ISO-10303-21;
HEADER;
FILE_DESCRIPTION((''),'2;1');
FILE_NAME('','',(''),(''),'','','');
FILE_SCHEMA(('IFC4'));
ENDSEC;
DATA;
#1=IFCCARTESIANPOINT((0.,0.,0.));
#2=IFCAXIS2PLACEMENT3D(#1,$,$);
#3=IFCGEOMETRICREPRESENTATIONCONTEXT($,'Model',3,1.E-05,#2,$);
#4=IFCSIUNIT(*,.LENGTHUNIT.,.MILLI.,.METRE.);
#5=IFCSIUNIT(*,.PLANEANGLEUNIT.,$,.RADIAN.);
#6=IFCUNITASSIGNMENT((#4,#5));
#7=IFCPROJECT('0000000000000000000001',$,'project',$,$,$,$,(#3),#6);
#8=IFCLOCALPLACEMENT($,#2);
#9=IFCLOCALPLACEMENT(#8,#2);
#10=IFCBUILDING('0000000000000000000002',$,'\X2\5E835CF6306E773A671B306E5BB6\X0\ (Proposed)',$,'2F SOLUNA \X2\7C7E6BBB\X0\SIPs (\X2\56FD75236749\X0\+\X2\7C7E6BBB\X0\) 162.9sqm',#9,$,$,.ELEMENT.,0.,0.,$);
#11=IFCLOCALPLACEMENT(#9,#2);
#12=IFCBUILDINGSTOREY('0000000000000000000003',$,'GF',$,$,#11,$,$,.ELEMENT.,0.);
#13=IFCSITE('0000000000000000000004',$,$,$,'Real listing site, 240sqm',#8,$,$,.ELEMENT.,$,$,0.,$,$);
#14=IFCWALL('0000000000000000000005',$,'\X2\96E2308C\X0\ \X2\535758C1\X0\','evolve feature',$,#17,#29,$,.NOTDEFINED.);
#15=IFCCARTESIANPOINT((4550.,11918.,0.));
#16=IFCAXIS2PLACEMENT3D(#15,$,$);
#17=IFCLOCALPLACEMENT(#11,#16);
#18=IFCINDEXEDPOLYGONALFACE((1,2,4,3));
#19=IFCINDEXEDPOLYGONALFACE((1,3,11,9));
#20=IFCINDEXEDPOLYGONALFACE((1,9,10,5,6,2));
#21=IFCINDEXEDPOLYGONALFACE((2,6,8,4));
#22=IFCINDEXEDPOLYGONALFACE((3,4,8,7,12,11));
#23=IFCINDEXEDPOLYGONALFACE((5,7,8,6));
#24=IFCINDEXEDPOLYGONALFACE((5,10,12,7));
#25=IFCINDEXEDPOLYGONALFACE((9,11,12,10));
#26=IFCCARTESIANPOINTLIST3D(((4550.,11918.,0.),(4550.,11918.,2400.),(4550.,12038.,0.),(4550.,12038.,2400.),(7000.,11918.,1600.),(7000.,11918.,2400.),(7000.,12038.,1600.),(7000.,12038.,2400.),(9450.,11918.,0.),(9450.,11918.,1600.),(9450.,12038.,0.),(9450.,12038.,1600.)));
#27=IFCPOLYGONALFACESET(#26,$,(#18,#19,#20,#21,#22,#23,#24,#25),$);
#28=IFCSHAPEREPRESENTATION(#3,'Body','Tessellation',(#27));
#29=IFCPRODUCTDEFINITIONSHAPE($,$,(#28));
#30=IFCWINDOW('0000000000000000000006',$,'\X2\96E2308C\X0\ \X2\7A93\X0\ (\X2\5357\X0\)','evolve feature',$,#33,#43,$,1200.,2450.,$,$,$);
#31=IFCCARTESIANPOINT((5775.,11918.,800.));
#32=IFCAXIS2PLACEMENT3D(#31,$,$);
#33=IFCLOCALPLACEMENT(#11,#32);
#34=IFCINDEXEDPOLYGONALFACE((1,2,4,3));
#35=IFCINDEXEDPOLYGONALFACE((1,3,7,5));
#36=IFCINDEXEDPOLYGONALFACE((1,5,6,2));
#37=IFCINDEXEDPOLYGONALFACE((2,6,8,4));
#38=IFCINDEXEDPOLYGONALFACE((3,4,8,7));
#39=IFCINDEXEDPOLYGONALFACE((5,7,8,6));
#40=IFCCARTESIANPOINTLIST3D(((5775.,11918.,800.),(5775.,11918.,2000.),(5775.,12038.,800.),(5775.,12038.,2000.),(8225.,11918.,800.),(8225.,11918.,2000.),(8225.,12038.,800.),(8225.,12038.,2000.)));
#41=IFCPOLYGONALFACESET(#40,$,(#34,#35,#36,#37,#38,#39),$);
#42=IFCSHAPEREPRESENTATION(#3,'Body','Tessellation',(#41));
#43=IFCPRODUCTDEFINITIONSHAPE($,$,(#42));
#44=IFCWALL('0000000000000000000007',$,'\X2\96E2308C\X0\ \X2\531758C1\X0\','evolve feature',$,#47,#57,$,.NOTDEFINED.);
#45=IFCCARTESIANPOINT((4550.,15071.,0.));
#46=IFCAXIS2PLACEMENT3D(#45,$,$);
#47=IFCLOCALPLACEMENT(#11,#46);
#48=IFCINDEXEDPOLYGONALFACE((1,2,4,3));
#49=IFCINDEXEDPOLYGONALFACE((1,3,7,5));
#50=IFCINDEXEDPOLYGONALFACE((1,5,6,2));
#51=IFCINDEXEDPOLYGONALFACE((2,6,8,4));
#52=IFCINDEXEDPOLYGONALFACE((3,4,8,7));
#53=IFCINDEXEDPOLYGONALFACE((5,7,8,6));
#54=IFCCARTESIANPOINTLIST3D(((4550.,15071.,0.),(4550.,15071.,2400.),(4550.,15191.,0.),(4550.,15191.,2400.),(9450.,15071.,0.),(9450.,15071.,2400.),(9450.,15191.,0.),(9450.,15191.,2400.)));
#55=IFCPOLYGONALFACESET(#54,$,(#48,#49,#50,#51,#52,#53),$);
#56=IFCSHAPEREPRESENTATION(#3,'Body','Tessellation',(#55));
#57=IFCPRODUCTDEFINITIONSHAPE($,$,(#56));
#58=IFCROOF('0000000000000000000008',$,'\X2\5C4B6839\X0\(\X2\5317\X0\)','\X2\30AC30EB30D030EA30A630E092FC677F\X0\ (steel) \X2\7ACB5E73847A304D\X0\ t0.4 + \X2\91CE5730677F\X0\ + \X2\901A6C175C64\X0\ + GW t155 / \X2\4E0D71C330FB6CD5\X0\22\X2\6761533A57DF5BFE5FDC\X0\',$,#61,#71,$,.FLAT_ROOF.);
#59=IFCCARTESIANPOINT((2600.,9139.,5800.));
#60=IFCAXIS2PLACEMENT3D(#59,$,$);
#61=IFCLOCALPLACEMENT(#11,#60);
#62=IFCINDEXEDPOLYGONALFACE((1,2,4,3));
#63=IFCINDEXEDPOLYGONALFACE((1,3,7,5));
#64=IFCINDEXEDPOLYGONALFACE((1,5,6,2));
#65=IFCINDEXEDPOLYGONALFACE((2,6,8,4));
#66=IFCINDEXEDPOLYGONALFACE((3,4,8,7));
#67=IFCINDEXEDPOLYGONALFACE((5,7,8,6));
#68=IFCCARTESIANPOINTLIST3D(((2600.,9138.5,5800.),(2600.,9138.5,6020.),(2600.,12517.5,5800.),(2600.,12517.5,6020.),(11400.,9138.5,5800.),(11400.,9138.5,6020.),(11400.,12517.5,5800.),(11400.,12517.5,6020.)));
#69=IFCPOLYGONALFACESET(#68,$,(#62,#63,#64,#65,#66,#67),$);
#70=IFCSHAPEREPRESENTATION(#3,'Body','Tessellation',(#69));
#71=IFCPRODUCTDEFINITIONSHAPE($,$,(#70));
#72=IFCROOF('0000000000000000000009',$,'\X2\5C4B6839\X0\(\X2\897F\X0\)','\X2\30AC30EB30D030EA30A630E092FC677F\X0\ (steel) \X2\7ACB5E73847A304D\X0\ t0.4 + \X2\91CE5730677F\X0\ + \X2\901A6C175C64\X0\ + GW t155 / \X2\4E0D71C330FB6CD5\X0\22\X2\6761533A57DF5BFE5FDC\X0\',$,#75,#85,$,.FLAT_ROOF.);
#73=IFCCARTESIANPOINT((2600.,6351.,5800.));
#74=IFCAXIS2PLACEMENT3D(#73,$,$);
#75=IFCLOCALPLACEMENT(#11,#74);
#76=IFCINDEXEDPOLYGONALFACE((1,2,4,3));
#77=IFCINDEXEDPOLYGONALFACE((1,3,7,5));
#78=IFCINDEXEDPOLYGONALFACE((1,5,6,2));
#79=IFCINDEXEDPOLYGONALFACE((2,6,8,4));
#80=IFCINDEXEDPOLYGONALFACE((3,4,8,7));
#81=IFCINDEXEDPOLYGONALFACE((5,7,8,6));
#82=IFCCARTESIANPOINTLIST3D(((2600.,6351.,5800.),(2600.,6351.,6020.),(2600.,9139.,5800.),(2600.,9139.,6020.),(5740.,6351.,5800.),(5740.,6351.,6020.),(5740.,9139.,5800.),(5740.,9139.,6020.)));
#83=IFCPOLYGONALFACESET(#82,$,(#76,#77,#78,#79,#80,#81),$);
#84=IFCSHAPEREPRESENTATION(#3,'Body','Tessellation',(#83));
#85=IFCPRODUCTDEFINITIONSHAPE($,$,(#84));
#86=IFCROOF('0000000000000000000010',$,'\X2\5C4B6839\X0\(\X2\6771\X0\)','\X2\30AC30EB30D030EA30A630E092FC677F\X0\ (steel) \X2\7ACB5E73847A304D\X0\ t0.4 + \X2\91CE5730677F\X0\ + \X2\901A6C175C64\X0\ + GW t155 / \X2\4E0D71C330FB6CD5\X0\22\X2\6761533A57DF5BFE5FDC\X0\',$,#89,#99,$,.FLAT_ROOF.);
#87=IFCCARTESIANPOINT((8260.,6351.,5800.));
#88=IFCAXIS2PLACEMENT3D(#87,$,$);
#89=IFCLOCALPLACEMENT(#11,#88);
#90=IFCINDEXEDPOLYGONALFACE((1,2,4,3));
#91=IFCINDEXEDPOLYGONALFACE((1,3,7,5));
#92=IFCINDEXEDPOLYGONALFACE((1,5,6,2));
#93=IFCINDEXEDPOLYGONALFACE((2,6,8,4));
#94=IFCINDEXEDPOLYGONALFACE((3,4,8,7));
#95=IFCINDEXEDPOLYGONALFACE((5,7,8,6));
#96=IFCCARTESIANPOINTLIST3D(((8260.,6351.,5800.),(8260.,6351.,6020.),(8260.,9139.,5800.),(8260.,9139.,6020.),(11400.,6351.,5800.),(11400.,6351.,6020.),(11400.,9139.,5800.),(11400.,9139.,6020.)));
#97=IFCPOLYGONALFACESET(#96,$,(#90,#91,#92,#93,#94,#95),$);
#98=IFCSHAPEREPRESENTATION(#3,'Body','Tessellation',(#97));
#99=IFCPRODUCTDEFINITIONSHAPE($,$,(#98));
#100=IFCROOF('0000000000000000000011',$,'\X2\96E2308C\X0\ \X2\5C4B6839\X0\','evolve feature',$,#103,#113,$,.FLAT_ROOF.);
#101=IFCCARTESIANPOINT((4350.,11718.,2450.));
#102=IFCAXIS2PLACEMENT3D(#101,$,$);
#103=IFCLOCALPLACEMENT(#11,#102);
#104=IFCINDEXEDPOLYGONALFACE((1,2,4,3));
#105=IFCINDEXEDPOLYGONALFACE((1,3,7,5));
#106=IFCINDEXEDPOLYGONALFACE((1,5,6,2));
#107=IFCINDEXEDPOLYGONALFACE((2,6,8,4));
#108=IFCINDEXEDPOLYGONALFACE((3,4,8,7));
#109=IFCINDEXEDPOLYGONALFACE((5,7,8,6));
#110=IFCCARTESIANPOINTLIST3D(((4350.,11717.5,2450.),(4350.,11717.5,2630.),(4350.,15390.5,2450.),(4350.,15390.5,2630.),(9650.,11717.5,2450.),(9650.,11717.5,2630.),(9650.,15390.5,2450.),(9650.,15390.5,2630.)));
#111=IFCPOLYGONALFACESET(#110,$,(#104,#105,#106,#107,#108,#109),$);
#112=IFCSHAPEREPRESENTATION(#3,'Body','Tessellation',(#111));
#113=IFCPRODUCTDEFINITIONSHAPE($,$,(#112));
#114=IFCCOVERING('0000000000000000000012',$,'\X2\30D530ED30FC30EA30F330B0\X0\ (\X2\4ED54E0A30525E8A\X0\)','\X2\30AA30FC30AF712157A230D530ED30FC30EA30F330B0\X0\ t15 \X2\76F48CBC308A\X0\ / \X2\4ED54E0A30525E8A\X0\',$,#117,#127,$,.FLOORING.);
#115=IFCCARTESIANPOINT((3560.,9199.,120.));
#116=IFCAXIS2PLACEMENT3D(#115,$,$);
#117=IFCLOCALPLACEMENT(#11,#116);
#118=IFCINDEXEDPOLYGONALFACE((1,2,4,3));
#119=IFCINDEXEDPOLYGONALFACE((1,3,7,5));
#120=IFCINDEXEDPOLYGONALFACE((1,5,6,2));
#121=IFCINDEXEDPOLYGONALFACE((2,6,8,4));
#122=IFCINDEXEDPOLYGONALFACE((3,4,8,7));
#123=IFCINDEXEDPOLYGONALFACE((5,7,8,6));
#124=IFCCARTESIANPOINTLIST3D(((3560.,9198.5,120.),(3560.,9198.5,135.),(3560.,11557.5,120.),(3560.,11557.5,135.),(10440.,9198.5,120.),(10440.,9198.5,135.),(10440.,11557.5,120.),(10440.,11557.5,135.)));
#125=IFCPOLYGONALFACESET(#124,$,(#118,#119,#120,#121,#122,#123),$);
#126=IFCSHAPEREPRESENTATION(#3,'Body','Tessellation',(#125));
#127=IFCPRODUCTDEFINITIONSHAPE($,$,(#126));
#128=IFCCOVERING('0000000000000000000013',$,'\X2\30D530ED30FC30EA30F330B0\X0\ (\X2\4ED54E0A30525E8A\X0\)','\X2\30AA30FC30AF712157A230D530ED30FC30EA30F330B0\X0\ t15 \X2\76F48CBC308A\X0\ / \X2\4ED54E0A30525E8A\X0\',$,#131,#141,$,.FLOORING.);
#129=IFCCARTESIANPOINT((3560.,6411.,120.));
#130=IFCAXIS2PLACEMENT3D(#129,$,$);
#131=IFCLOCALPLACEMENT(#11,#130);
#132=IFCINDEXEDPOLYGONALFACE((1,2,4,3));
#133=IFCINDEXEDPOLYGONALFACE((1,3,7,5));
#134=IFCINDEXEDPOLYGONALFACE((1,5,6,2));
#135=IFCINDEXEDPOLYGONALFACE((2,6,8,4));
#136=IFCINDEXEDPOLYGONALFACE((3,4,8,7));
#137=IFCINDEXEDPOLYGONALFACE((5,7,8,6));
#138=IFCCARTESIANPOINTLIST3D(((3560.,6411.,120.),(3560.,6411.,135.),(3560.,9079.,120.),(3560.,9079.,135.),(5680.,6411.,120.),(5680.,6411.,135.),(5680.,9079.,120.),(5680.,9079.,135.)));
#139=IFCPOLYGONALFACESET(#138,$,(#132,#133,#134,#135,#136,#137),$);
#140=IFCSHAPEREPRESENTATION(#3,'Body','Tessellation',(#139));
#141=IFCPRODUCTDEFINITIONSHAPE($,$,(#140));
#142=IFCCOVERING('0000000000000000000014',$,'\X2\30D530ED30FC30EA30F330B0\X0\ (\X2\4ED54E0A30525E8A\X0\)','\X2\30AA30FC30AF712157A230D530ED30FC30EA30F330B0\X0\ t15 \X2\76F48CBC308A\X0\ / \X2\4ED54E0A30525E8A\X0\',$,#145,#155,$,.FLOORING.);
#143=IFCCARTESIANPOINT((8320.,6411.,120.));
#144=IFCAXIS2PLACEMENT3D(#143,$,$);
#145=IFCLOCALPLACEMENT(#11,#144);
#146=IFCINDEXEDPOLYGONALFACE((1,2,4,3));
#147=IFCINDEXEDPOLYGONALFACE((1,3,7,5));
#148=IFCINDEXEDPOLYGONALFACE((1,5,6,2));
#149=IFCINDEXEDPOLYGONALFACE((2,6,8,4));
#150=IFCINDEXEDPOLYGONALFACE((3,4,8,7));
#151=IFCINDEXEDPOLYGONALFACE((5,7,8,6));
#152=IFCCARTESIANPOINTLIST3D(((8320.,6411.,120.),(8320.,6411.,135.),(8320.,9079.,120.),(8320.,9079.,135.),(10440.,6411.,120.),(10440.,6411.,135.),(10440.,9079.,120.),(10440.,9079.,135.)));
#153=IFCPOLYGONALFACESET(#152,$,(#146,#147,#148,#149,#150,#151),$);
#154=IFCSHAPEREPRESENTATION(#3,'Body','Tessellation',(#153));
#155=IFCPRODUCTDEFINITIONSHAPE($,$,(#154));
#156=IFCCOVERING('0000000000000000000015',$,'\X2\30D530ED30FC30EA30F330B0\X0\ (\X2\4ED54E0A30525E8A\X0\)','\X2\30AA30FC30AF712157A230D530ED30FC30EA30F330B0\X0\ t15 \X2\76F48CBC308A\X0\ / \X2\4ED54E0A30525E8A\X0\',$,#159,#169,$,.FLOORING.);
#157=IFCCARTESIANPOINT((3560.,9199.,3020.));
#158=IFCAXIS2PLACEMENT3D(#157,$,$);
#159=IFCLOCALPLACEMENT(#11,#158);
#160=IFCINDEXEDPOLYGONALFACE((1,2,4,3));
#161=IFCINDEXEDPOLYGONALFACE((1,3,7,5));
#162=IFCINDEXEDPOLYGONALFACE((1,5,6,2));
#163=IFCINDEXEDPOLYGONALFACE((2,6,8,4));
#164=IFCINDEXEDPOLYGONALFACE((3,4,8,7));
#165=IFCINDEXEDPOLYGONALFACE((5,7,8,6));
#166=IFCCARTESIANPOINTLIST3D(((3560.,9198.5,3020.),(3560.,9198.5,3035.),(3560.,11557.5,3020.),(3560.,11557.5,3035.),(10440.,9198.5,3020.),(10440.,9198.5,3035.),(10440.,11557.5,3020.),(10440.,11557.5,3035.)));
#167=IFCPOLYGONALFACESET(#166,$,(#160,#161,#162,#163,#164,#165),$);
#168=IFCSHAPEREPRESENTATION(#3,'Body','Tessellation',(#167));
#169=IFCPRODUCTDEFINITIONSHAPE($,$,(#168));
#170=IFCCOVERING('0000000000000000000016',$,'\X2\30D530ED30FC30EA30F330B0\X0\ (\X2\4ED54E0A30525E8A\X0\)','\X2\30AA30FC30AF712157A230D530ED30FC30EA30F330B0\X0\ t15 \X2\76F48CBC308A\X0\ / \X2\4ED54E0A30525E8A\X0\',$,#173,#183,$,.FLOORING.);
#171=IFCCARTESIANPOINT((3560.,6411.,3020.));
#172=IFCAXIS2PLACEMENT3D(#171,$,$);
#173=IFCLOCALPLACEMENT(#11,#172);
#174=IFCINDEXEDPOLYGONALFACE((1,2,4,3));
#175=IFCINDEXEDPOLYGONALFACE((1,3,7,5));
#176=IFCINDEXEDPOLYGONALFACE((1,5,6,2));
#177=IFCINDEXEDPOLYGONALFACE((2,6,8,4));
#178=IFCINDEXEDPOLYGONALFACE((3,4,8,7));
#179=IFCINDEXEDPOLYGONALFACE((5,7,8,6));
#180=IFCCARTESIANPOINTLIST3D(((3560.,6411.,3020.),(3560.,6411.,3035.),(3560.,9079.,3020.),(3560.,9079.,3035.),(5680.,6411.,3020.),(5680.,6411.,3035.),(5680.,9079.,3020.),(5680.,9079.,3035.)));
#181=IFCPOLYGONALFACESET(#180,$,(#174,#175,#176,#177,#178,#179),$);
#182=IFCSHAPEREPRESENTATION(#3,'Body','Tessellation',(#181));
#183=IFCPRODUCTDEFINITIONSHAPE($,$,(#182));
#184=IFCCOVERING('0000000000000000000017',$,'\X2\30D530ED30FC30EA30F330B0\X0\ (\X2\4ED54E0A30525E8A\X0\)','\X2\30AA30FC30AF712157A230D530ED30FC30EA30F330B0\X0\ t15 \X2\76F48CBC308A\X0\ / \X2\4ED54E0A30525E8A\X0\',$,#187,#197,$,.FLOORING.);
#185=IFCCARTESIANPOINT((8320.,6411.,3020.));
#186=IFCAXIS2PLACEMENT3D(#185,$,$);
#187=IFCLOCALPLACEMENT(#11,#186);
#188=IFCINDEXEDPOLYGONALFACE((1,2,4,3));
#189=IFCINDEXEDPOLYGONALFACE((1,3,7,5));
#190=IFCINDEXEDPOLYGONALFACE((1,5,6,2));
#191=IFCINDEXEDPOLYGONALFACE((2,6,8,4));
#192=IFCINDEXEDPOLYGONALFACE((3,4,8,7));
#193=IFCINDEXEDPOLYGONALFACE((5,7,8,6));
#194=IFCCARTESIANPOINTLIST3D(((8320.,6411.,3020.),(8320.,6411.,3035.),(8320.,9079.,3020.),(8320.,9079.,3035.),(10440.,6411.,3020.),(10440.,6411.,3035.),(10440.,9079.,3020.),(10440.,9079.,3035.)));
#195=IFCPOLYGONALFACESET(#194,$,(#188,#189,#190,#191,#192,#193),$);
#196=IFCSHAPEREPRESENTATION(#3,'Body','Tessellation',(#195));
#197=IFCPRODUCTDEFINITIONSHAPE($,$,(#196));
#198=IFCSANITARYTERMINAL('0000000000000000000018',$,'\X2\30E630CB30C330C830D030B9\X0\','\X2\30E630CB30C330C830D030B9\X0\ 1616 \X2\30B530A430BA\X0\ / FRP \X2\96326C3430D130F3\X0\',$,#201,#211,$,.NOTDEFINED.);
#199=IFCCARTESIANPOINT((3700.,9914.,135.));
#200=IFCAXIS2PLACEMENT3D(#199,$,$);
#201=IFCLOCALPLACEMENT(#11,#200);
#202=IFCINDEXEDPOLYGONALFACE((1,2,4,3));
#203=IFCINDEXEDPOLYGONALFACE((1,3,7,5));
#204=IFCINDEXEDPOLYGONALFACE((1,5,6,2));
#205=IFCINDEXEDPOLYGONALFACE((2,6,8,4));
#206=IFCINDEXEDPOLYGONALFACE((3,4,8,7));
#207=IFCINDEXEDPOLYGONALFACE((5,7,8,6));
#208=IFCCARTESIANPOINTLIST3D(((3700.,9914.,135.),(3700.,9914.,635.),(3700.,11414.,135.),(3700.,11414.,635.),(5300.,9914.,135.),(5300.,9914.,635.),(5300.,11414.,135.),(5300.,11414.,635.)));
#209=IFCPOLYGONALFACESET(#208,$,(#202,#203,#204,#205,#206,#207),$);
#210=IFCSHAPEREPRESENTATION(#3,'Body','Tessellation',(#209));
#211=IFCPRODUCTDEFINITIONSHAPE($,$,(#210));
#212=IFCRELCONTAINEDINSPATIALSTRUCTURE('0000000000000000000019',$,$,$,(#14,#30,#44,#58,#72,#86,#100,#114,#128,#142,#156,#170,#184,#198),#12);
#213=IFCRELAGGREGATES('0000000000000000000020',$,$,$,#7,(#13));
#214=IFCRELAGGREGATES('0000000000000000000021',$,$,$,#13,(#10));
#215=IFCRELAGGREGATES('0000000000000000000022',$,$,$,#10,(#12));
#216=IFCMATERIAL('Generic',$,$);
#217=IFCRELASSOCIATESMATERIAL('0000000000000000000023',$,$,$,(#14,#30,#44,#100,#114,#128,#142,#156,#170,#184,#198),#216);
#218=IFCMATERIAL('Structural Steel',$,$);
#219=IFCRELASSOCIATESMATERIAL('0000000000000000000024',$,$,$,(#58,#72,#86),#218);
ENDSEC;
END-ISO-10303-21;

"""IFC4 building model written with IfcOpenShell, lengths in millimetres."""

from ifc_helpers import new_model, si_unit, frame, frame_2d, origin, place, context, project, spatial, rectangle, extrude, material, element, fill, save


model = new_model("IFC4")

# Units and contexts
model_context = context("Model", 3, precision=1e-05, world=origin())
ifc_project = project(units=[si_unit("LENGTHUNIT", "METRE", prefix="MILLI"), si_unit("PLANEANGLEUNIT", "RADIAN")], contexts=[model_context])

# Site, building, storey
site_placement = place(None, origin())
site = spatial("IfcSite", under=ifc_project, at=site_placement, ObjectType="Real listing site, 240sqm", CompositionType="ELEMENT", RefElevation=0.0)
building_placement = place(site_placement, origin())
building = spatial("IfcBuilding", under=site, at=building_placement, Name="広島の眺望の家 (Proposed)", ObjectType="2F SOLUNA 籾殻SIPs (国産杉+籾殻) 162.9sqm", CompositionType="ELEMENT", ElevationOfRefHeight=0.0, ElevationOfTerrain=0.0)
storey_placement = place(building_placement, origin())
storey = spatial("IfcBuildingStorey", under=building, at=storey_placement, Name="GF", CompositionType="ELEMENT", Elevation=0.0)

# Shared definitions
ifc_material_1 = material(Name="Generic")

# Wall, opening, window
wall_1_placement = place(storey_placement, frame((4550.0, 11918.0, 0.0)))
wall_1 = element("IfcWall", 1, at=wall_1_placement, inside=storey, material=ifc_material_1, Name="離れ 南壁", Description="evolve feature", PredefinedType="NOTDEFINED", context=model_context, shape_type="SweptSolid", body=[
    extrude(rectangle(XDim=4900.0, YDim=120.0, at=frame_2d((2450.0, 60.0))), frame((4550.0, 11918.0, 0.0)), (0.0, 0.0, 1.0), 2400.0),
])
opening_1_placement = place(storey_placement, frame((5775.0, 11918.0, 800.0)))
opening_1 = element("IfcOpeningElement", 2, at=opening_1_placement, cuts=wall_1, PredefinedType="NOTDEFINED", context=model_context, shape_type="SweptSolid", body=[
    extrude(rectangle(XDim=2450.0, YDim=120.0, at=frame_2d((1225.0, 60.0))), frame((5775.0, 11918.0, 800.0)), (0.0, 0.0, 1.0), 1200.0),
])
window_1_placement = place(storey_placement, frame((5775.0, 11918.0, 800.0)))
window_1 = element("IfcWindow", 3, at=window_1_placement, inside=storey, material=ifc_material_1, Name="離れ 窓 (南)", Description="evolve feature", OverallHeight=1200.0, OverallWidth=2450.0, context=model_context, shape_type="SweptSolid", body=[
    extrude(rectangle(XDim=2450.0, YDim=120.0, at=frame_2d((1225.0, 60.0))), frame((5775.0, 11918.0, 800.0)), (0.0, 0.0, 1.0), 1200.0),
])
fill(opening_1, window_1)

# Wall
wall_2_placement = place(storey_placement, frame((4550.0, 15071.0, 0.0)))
element("IfcWall", 4, at=wall_2_placement, inside=storey, material=ifc_material_1, Name="離れ 北壁", Description="evolve feature", PredefinedType="NOTDEFINED", context=model_context, shape_type="SweptSolid", body=[
    extrude(rectangle(XDim=4900.0, YDim=120.0, at=frame_2d((2450.0, 60.0))), frame((4550.0, 15071.0, 0.0)), (0.0, 0.0, 1.0), 2400.0),
])

# Roofs
ifc_material_2 = material(Name="Structural Steel")
for number, where, name in (
    (5, (2600.0, 9139.0, 5800.0), "屋根(北)"),
):
    element("IfcRoof", number, at=place(storey_placement, frame(where)), inside=storey, material=ifc_material_2, Name=name, Description="ガルバリウム鋼板 (steel) 立平葺き t0.4 + 野地板 + 通気層 + GW t155 / 不燃・法22条区域対応", PredefinedType="FLAT_ROOF", context=model_context, shape_type="SweptSolid", body=[
        extrude(rectangle(XDim=8800.0, YDim=3379.0, at=frame_2d((4400.0, 1689.0))), frame((2600.0, 9139.0, 5800.0)), (0.0, 0.0, 1.0), 220.0),
    ])
roof_1_placement = place(storey_placement, frame((2600.0, 6351.0, 5800.0)))
element("IfcRoof", 6, at=roof_1_placement, inside=storey, material=ifc_material_2, Name="屋根(西)", Description="ガルバリウム鋼板 (steel) 立平葺き t0.4 + 野地板 + 通気層 + GW t155 / 不燃・法22条区域対応", PredefinedType="FLAT_ROOF", context=model_context, shape_type="SweptSolid", body=[
    extrude(rectangle(XDim=3140.0, YDim=2788.0, at=frame_2d((1570.0, 1394.0))), frame((2600.0, 6351.0, 5800.0)), (0.0, 0.0, 1.0), 220.0),
])
roof_2_placement = place(storey_placement, frame((8260.0, 6351.0, 5800.0)))
element("IfcRoof", 7, at=roof_2_placement, inside=storey, material=ifc_material_2, Name="屋根(東)", Description="ガルバリウム鋼板 (steel) 立平葺き t0.4 + 野地板 + 通気層 + GW t155 / 不燃・法22条区域対応", PredefinedType="FLAT_ROOF", context=model_context, shape_type="SweptSolid", body=[
    extrude(rectangle(XDim=3140.0, YDim=2788.0, at=frame_2d((1570.0, 1394.0))), frame((8260.0, 6351.0, 5800.0)), (0.0, 0.0, 1.0), 220.0),
])
roof_3_placement = place(storey_placement, frame((4350.0, 11718.0, 2450.0)))
element("IfcRoof", 8, at=roof_3_placement, inside=storey, material=ifc_material_1, Name="離れ 屋根", Description="evolve feature", PredefinedType="FLAT_ROOF", context=model_context, shape_type="SweptSolid", body=[
    extrude(rectangle(XDim=5300.0, YDim=3673.0, at=frame_2d((2650.0, 1836.0))), frame((4350.0, 11718.0, 2450.0)), (0.0, 0.0, 1.0), 180.0),
])

# Coverings
covering_1_placement = place(storey_placement, frame((3560.0, 9199.0, 120.0)))
element("IfcCovering", 9, at=covering_1_placement, inside=storey, material=ifc_material_1, Name="フローリング (仕上げ床)", Description="オーク無垢フローリング t15 直貼り / 仕上げ床", PredefinedType="FLOORING", context=model_context, shape_type="SweptSolid", body=[
    extrude(rectangle(XDim=6880.0, YDim=2359.0, at=frame_2d((3440.0, 1179.0))), frame((3560.0, 9199.0, 120.0)), (0.0, 0.0, 1.0), 15.0),
])
covering_2_placement = place(storey_placement, frame((3560.0, 6411.0, 120.0)))
element("IfcCovering", 10, at=covering_2_placement, inside=storey, material=ifc_material_1, Name="フローリング (仕上げ床)", Description="オーク無垢フローリング t15 直貼り / 仕上げ床", PredefinedType="FLOORING", context=model_context, shape_type="SweptSolid", body=[
    extrude(rectangle(XDim=2120.0, YDim=2668.0, at=frame_2d((1060.0, 1334.0))), frame((3560.0, 6411.0, 120.0)), (0.0, 0.0, 1.0), 15.0),
])
covering_3_placement = place(storey_placement, frame((8320.0, 6411.0, 120.0)))
element("IfcCovering", 11, at=covering_3_placement, inside=storey, material=ifc_material_1, Name="フローリング (仕上げ床)", Description="オーク無垢フローリング t15 直貼り / 仕上げ床", PredefinedType="FLOORING", context=model_context, shape_type="SweptSolid", body=[
    extrude(rectangle(XDim=2120.0, YDim=2668.0, at=frame_2d((1060.0, 1334.0))), frame((8320.0, 6411.0, 120.0)), (0.0, 0.0, 1.0), 15.0),
])
covering_4_placement = place(storey_placement, frame((3560.0, 9199.0, 3020.0)))
element("IfcCovering", 12, at=covering_4_placement, inside=storey, material=ifc_material_1, Name="フローリング (仕上げ床)", Description="オーク無垢フローリング t15 直貼り / 仕上げ床", PredefinedType="FLOORING", context=model_context, shape_type="SweptSolid", body=[
    extrude(rectangle(XDim=6880.0, YDim=2359.0, at=frame_2d((3440.0, 1179.0))), frame((3560.0, 9199.0, 3020.0)), (0.0, 0.0, 1.0), 15.0),
])
covering_5_placement = place(storey_placement, frame((3560.0, 6411.0, 3020.0)))
element("IfcCovering", 13, at=covering_5_placement, inside=storey, material=ifc_material_1, Name="フローリング (仕上げ床)", Description="オーク無垢フローリング t15 直貼り / 仕上げ床", PredefinedType="FLOORING", context=model_context, shape_type="SweptSolid", body=[
    extrude(rectangle(XDim=2120.0, YDim=2668.0, at=frame_2d((1060.0, 1334.0))), frame((3560.0, 6411.0, 3020.0)), (0.0, 0.0, 1.0), 15.0),
])
covering_6_placement = place(storey_placement, frame((8320.0, 6411.0, 3020.0)))
element("IfcCovering", 14, at=covering_6_placement, inside=storey, material=ifc_material_1, Name="フローリング (仕上げ床)", Description="オーク無垢フローリング t15 直貼り / 仕上げ床", PredefinedType="FLOORING", context=model_context, shape_type="SweptSolid", body=[
    extrude(rectangle(XDim=2120.0, YDim=2668.0, at=frame_2d((1060.0, 1334.0))), frame((8320.0, 6411.0, 3020.0)), (0.0, 0.0, 1.0), 15.0),
])

# Sanitary terminal
sanitary_terminal_1_placement = place(storey_placement, frame((3700.0, 9914.0, 135.0)))
element("IfcSanitaryTerminal", 15, at=sanitary_terminal_1_placement, inside=storey, material=ifc_material_1, Name="ユニットバス", Description="ユニットバス 1616 サイズ / FRP 防水パン", PredefinedType="NOTDEFINED", context=model_context, shape_type="SweptSolid", body=[
    extrude(rectangle(XDim=1600.0, YDim=1500.0, at=frame_2d((800.0, 750.0))), frame((3700.0, 9914.0, 135.0)), (0.0, 0.0, 1.0), 500.0),
])

save(model, "model.ifc")
